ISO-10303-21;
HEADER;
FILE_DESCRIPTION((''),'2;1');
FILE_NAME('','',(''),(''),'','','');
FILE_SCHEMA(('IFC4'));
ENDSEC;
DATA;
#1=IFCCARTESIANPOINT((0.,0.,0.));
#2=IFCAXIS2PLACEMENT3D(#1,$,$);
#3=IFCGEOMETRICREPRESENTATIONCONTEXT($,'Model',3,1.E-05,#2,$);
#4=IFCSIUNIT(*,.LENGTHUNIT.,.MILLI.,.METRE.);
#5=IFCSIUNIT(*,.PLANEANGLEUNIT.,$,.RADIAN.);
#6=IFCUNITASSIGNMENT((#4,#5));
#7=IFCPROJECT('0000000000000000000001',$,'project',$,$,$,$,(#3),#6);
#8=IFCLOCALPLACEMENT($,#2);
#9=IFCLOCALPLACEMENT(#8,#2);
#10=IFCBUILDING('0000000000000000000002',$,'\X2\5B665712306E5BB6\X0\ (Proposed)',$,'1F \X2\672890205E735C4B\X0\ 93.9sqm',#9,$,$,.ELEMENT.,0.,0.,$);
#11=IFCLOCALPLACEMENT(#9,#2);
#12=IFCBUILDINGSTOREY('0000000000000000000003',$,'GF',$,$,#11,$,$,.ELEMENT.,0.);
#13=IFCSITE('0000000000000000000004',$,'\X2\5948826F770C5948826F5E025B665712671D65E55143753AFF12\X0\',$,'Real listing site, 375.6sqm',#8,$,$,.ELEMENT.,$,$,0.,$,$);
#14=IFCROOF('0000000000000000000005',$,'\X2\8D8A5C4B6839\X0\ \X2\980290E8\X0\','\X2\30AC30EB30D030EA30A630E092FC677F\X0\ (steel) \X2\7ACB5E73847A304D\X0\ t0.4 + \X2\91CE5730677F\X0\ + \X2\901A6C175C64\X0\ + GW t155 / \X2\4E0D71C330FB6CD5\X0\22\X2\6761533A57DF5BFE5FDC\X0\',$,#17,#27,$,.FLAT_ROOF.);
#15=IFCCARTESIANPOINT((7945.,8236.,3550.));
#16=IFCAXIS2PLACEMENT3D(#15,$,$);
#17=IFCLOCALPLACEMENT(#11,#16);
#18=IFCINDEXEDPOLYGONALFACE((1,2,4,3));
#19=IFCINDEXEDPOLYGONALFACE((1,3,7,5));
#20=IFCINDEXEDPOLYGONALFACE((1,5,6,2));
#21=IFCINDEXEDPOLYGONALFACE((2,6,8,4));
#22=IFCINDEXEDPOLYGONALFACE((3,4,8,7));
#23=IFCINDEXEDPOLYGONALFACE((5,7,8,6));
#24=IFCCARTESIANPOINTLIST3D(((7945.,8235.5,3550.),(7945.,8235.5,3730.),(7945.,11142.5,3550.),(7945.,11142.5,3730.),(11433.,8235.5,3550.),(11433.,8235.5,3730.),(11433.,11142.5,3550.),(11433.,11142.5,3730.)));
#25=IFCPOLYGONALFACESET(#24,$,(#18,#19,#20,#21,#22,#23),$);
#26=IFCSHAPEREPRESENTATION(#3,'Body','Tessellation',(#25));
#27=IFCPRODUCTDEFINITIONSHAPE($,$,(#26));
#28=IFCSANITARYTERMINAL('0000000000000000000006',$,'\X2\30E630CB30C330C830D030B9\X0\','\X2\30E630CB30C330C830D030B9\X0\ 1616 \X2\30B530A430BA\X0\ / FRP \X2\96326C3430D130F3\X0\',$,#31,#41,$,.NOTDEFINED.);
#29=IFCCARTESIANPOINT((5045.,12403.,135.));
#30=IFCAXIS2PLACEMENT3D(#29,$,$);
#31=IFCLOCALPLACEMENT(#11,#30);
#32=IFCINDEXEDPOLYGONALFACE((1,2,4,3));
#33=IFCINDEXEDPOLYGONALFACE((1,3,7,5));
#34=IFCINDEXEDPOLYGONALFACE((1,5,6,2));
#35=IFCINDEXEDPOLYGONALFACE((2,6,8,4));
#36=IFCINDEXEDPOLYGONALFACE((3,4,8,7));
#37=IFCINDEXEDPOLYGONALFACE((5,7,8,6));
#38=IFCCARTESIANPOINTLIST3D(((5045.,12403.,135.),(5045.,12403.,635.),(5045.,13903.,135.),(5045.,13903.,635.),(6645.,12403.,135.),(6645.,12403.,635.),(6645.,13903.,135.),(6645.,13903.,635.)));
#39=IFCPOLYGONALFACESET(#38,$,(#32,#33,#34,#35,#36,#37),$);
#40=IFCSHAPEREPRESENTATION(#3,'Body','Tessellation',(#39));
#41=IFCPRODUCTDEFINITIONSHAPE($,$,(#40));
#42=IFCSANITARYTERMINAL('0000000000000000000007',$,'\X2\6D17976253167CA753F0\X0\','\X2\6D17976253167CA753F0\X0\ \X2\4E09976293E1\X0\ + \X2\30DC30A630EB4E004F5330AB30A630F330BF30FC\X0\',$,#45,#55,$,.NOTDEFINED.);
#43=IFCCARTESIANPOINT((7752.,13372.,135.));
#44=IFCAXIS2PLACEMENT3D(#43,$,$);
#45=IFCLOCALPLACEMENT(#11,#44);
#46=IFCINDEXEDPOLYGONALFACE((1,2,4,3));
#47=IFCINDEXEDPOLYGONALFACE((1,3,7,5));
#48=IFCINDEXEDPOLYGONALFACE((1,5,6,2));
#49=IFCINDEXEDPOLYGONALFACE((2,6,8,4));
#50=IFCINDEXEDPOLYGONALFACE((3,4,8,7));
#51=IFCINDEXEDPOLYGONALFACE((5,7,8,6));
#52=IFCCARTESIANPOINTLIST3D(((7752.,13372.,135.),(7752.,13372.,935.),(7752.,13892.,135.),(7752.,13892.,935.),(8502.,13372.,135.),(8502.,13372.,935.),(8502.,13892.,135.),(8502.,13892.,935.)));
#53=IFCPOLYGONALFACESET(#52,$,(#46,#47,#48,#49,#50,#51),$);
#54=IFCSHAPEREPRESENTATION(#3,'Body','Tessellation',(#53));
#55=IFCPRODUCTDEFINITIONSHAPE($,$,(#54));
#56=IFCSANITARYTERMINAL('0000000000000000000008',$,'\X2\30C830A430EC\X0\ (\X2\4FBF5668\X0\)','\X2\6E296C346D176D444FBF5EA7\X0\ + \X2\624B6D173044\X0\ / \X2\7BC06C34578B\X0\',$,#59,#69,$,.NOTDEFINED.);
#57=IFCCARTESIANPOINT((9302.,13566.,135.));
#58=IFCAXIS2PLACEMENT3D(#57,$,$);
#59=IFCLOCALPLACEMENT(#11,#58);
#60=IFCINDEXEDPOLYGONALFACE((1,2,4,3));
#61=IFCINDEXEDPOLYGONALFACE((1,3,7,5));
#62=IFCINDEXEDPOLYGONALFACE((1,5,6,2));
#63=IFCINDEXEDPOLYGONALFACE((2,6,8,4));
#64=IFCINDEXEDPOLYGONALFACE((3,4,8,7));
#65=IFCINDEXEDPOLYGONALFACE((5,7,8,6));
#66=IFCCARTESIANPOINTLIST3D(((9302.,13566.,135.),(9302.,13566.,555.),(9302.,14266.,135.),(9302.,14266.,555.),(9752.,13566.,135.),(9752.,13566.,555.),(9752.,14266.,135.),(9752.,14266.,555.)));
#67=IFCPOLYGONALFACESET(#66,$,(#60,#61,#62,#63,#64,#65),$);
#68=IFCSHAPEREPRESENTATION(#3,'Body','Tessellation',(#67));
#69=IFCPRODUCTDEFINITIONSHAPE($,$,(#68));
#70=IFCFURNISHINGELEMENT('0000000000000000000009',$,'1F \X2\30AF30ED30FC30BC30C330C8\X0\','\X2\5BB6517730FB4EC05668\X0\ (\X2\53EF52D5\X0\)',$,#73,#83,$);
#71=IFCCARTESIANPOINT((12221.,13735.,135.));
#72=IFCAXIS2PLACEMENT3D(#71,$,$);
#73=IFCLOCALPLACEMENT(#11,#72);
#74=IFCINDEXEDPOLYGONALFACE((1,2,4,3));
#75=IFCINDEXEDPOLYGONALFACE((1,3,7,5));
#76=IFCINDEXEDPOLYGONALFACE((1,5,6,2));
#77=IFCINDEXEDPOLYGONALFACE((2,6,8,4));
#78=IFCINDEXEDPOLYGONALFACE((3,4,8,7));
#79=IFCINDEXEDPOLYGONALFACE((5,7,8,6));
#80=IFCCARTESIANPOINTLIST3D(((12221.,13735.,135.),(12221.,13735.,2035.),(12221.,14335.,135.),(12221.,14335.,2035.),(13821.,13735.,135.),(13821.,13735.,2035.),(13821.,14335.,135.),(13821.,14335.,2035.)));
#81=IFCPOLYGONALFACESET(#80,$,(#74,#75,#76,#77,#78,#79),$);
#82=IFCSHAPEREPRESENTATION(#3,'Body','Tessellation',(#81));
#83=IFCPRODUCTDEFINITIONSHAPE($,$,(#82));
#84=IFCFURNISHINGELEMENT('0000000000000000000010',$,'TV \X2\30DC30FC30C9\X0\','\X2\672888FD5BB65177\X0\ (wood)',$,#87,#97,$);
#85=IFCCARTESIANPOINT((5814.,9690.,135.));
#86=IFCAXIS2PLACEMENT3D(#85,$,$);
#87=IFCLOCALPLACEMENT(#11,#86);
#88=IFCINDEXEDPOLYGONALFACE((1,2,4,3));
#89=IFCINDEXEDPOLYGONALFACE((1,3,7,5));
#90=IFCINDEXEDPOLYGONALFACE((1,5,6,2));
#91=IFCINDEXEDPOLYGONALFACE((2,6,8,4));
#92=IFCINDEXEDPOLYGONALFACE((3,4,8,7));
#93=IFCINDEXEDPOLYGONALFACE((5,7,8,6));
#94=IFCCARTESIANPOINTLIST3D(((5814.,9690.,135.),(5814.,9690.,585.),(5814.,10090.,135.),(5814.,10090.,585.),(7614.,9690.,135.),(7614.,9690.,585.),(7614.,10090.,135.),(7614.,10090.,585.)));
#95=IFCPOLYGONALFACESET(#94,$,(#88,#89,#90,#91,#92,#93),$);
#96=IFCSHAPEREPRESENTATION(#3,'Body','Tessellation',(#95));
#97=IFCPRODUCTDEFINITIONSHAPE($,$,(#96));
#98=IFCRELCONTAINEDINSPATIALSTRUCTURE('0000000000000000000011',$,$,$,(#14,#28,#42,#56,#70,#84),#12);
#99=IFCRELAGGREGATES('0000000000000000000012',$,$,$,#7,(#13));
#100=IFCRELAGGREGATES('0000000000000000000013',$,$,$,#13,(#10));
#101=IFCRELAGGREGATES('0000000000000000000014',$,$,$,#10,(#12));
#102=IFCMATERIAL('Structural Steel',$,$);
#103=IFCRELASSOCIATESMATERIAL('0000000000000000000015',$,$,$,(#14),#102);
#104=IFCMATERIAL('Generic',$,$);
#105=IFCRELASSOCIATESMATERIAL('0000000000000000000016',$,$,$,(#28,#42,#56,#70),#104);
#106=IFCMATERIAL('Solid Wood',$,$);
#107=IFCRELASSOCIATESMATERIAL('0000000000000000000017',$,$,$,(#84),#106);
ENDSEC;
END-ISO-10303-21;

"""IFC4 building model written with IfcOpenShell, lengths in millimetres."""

from ifc_helpers import new_model, si_unit, frame, frame_2d, origin, place, context, project, spatial, rectangle, extrude, material, element, save


model = new_model("IFC4")

# Units and contexts
model_context = context("Model", 3, precision=1e-05, world=origin())
ifc_project = project(units=[si_unit("LENGTHUNIT", "METRE", prefix="MILLI"), si_unit("PLANEANGLEUNIT", "RADIAN")], contexts=[model_context])

# Site, building, storey
site_placement = place(None, origin())
site = spatial("IfcSite", under=ifc_project, at=site_placement, Name="奈良県奈良市学園朝日元町２", ObjectType="Real listing site, 375.6sqm", CompositionType="ELEMENT", RefElevation=0.0)
building_placement = place(site_placement, origin())
building = spatial("IfcBuilding", under=site, at=building_placement, Name="学園の家 (Proposed)", ObjectType="1F 木造平屋 93.9sqm", CompositionType="ELEMENT", ElevationOfRefHeight=0.0, ElevationOfTerrain=0.0)
storey_placement = place(building_placement, origin())
storey = spatial("IfcBuildingStorey", under=building, at=storey_placement, Name="GF", CompositionType="ELEMENT", Elevation=0.0)

# Shared definitions
ifc_material_1 = material(Name="Solid Wood")

# Roof
ifc_material_2 = material(Name="Structural Steel")
roof_placement = place(storey_placement, frame((7945.0, 8236.0, 3550.0)))
element("IfcRoof", 1, at=roof_placement, inside=storey, material=ifc_material_2, Name="越屋根 頂部", Description="ガルバリウム鋼板 (steel) 立平葺き t0.4 + 野地板 + 通気層 + GW t155 / 不燃・法22条区域対応", PredefinedType="FLAT_ROOF", context=model_context, shape_type="SweptSolid", body=[
    extrude(rectangle(XDim=3488.0, YDim=2907.0, at=frame_2d((1744.0, 1453.0))), frame((7945.0, 8236.0, 3550.0)), (0.0, 0.0, 1.0), 180.0),
])

# Sanitary terminals
ifc_material_3 = material(Name="Generic")
sanitary_terminal_1_placement = place(storey_placement, frame((5045.0, 12403.0, 135.0)))
element("IfcSanitaryTerminal", 2, at=sanitary_terminal_1_placement, inside=storey, material=ifc_material_3, Name="ユニットバス", Description="ユニットバス 1616 サイズ / FRP 防水パン", PredefinedType="NOTDEFINED", context=model_context, shape_type="SweptSolid", body=[
    extrude(rectangle(XDim=1600.0, YDim=1500.0, at=frame_2d((800.0, 750.0))), frame((5045.0, 12403.0, 135.0)), (0.0, 0.0, 1.0), 500.0),
])
sanitary_terminal_2_placement = place(storey_placement, frame((7752.0, 13372.0, 135.0)))
element("IfcSanitaryTerminal", 3, at=sanitary_terminal_2_placement, inside=storey, material=ifc_material_3, Name="洗面化粧台", Description="洗面化粧台 三面鏡 + ボウル一体カウンター", PredefinedType="NOTDEFINED", context=model_context, shape_type="SweptSolid", body=[
    extrude(rectangle(XDim=750.0, YDim=520.0, at=frame_2d((375.0, 260.0))), frame((7752.0, 13372.0, 135.0)), (0.0, 0.0, 1.0), 800.0),
])
sanitary_terminal_3_placement = place(storey_placement, frame((9302.0, 13566.0, 135.0)))
element("IfcSanitaryTerminal", 4, at=sanitary_terminal_3_placement, inside=storey, material=ifc_material_3, Name="トイレ (便器)", Description="温水洗浄便座 + 手洗い / 節水型", PredefinedType="NOTDEFINED", context=model_context, shape_type="SweptSolid", body=[
    extrude(rectangle(XDim=450.0, YDim=700.0, at=frame_2d((225.0, 350.0))), frame((9302.0, 13566.0, 135.0)), (0.0, 0.0, 1.0), 420.0),
])

# Furnishing elements
furnishing_1_placement = place(storey_placement, frame((12221.0, 13735.0, 135.0)))
element("IfcFurnishingElement", 5, at=furnishing_1_placement, inside=storey, material=ifc_material_3, Name="1F クローゼット", Description="家具・什器 (可動)", context=model_context, shape_type="SweptSolid", body=[
    extrude(rectangle(XDim=1600.0, YDim=600.0, at=frame_2d((800.0, 300.0))), frame((12221.0, 13735.0, 135.0)), (0.0, 0.0, 1.0), 1900.0),
])
furnishing_2_placement = place(storey_placement, frame((5814.0, 9690.0, 135.0)))
element("IfcFurnishingElement", 6, at=furnishing_2_placement, inside=storey, material=ifc_material_1, Name="TV ボード", Description="木製家具 (wood)", context=model_context, shape_type="SweptSolid", body=[
    extrude(rectangle(XDim=1800.0, YDim=400.0, at=frame_2d((900.0, 200.0))), frame((5814.0, 9690.0, 135.0)), (0.0, 0.0, 1.0), 450.0),
])

save(model, "model.ifc")
